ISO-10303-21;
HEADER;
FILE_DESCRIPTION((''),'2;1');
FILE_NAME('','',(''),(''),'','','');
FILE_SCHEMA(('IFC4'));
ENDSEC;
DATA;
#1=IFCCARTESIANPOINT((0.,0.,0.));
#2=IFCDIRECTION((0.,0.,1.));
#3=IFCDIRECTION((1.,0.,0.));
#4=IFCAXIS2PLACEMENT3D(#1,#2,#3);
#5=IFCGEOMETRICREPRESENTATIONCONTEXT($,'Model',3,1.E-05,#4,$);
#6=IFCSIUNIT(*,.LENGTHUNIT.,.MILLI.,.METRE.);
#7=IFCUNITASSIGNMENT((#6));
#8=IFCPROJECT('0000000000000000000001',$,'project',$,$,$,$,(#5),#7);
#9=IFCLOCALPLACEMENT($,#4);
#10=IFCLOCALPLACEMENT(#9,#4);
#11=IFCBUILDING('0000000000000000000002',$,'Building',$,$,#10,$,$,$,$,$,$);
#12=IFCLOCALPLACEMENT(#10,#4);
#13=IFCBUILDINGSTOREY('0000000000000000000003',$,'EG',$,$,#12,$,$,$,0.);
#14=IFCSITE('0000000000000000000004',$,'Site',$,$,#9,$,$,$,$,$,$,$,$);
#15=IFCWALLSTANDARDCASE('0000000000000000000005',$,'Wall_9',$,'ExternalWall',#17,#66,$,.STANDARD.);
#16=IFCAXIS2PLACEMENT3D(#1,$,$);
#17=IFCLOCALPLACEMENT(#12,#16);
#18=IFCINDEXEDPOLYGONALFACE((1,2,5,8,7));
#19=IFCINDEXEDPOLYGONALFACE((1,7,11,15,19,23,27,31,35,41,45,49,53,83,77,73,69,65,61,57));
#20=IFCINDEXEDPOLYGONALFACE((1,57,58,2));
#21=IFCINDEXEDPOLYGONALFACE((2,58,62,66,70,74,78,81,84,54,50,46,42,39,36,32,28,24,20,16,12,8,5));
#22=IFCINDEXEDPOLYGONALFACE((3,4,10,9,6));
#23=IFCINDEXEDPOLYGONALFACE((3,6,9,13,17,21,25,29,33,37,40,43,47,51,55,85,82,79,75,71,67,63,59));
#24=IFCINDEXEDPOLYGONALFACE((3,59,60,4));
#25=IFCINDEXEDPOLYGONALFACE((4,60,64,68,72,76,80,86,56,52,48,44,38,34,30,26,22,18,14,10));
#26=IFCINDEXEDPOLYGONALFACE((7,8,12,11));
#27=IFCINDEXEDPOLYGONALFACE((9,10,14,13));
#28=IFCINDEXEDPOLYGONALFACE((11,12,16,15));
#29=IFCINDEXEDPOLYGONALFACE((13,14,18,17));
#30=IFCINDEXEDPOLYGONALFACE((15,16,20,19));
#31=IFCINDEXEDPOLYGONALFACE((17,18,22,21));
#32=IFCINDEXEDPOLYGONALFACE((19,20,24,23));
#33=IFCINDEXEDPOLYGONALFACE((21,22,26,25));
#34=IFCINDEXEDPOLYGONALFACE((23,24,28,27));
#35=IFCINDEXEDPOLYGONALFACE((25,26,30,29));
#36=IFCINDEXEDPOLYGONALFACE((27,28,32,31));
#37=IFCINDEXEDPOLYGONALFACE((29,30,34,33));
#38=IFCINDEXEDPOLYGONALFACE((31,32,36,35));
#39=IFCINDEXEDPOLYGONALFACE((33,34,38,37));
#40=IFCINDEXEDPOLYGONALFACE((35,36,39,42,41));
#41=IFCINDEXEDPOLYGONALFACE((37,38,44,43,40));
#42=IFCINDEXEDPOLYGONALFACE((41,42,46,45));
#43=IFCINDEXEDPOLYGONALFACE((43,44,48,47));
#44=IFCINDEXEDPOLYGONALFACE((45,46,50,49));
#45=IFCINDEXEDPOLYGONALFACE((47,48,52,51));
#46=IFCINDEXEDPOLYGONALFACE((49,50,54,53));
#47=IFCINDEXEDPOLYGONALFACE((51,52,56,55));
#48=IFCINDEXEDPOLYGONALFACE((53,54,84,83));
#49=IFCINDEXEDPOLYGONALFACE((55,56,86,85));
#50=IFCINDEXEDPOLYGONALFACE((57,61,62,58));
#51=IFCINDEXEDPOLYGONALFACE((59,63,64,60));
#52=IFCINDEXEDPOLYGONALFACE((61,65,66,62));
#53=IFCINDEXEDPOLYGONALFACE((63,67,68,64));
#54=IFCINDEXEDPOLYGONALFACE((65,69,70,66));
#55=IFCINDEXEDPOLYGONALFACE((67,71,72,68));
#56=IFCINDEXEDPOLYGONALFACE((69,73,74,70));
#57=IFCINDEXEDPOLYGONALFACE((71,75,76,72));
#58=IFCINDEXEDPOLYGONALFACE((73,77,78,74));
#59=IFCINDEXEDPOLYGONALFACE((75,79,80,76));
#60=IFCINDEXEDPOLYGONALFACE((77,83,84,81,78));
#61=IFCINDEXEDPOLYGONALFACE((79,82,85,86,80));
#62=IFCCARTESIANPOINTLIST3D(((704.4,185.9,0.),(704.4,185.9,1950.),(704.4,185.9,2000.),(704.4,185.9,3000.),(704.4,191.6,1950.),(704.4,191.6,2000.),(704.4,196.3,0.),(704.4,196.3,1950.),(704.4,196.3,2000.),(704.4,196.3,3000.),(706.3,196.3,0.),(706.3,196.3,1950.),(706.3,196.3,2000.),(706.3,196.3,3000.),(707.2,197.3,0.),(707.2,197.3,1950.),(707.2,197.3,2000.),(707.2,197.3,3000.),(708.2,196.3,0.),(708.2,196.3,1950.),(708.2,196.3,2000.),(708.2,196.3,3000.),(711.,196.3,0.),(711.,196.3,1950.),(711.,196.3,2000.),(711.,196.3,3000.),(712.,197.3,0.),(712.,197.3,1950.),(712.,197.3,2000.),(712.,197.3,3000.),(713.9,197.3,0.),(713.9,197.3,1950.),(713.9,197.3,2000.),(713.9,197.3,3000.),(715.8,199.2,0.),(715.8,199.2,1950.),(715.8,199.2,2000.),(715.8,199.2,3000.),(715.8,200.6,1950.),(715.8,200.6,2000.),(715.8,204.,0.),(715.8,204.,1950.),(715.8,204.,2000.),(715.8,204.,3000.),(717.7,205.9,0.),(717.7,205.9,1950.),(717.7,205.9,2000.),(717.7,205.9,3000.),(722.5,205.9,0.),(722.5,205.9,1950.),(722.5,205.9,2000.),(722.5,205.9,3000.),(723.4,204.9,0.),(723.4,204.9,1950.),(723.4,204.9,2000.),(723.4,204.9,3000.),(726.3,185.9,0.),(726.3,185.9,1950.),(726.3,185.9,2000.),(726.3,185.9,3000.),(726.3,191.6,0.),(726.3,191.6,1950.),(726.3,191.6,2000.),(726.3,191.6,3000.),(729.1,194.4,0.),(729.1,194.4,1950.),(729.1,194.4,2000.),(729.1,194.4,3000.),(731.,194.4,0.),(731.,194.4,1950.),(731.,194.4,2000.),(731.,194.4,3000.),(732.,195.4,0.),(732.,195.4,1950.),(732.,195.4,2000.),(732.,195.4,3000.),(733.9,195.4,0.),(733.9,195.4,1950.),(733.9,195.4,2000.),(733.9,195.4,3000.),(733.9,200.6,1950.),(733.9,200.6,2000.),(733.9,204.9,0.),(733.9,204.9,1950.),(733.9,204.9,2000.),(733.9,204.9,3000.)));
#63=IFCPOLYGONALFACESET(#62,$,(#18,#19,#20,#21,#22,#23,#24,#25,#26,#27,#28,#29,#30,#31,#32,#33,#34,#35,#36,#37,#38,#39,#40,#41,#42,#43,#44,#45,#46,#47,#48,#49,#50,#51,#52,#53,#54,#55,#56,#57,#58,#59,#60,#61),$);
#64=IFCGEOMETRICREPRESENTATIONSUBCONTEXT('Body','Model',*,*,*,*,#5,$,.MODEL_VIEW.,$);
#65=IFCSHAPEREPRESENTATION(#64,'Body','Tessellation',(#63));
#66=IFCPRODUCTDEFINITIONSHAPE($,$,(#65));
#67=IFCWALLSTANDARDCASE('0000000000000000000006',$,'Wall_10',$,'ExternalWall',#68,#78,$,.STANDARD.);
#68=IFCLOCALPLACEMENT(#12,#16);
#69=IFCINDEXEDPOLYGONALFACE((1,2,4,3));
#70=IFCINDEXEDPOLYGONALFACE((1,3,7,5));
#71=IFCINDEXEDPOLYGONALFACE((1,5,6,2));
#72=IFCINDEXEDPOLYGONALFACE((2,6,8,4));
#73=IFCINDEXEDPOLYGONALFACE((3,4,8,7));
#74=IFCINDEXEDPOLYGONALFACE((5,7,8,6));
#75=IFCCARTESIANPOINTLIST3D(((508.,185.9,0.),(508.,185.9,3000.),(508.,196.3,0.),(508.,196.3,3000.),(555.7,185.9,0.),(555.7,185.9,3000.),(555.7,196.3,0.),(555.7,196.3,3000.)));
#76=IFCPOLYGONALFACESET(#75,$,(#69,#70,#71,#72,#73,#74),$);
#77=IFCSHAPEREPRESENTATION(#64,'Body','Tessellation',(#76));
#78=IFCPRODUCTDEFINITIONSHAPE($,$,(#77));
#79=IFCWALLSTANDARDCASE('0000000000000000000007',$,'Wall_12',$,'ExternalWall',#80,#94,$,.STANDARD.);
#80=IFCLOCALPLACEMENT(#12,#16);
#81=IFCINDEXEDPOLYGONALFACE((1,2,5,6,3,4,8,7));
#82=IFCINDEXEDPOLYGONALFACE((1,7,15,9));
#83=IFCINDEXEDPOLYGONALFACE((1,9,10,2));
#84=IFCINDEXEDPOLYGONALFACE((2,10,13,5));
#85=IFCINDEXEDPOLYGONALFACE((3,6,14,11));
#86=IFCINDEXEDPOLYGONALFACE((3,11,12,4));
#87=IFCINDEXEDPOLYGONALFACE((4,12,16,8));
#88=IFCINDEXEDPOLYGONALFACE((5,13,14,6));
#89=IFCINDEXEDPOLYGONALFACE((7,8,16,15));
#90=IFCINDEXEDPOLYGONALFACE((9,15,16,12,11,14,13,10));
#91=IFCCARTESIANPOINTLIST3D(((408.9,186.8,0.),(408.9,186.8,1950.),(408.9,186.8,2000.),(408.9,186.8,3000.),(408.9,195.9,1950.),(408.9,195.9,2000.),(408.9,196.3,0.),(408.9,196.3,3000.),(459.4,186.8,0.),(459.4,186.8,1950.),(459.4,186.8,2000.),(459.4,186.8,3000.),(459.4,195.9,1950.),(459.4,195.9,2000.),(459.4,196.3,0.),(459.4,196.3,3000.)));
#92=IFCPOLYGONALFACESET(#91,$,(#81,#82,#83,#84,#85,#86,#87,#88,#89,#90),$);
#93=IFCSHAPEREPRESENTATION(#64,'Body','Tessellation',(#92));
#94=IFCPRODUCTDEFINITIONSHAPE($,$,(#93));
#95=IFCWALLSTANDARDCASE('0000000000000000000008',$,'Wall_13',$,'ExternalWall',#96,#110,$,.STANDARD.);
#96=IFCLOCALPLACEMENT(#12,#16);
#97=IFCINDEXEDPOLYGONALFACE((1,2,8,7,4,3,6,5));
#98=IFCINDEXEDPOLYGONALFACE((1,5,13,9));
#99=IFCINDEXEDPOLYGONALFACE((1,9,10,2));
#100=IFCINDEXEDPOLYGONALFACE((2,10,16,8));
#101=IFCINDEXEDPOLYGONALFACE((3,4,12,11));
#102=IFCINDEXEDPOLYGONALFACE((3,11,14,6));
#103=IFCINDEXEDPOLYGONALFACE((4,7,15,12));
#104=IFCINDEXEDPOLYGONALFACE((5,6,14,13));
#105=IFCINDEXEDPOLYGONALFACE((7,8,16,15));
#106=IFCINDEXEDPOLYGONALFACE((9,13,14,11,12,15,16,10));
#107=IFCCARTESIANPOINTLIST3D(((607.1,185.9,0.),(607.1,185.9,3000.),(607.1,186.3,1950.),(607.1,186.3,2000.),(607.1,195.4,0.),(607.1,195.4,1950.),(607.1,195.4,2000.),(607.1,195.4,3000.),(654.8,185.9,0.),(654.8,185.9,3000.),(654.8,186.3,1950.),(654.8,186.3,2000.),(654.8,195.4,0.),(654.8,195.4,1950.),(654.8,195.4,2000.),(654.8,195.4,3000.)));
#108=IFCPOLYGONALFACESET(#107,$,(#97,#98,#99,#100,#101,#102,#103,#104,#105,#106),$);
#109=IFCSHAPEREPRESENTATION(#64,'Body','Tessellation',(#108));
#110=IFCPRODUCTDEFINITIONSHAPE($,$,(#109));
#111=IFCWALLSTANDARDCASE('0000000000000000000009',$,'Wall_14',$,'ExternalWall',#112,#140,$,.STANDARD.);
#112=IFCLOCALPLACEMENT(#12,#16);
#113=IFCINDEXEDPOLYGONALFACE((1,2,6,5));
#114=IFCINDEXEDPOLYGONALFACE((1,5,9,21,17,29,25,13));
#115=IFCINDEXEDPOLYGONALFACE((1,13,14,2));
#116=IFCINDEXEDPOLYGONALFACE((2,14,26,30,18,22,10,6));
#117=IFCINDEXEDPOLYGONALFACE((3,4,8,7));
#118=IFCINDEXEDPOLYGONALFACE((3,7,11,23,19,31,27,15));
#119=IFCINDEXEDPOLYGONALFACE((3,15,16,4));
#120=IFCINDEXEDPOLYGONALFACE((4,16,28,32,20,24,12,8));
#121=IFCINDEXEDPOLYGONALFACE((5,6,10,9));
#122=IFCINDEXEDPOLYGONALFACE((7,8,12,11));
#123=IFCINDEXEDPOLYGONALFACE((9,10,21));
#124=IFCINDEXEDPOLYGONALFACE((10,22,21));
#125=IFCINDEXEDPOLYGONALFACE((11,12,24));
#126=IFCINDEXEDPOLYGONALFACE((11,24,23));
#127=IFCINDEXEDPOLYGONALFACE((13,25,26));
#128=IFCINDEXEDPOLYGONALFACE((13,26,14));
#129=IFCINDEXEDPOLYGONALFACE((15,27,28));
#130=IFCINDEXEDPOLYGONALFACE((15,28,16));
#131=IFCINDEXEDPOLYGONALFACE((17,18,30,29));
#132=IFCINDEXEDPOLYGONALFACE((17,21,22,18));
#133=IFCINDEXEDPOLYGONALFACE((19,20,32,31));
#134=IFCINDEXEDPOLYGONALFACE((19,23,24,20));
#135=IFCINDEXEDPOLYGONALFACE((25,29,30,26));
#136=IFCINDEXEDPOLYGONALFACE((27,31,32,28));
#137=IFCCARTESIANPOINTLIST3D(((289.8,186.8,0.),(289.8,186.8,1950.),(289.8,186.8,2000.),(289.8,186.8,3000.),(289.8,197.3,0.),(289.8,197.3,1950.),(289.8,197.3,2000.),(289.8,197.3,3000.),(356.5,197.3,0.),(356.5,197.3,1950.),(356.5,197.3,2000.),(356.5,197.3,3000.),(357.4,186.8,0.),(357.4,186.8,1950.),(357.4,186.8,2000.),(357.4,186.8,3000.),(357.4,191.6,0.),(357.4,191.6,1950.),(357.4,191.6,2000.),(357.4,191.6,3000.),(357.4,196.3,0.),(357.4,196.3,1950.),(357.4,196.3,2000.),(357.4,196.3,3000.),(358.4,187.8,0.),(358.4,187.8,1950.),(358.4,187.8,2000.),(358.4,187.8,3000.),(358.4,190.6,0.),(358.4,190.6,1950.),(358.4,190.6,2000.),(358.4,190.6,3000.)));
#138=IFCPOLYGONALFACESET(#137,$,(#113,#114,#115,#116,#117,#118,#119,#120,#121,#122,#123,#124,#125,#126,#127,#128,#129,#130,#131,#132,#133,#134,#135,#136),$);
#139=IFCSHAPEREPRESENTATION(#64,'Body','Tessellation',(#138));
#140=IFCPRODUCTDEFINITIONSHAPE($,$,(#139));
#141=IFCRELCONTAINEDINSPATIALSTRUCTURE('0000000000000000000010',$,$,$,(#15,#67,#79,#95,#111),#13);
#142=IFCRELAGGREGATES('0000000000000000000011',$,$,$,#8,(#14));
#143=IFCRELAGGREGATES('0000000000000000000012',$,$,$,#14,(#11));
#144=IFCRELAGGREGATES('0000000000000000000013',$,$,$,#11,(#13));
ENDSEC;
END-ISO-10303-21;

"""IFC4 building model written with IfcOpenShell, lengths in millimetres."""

from ifc_helpers import new_model, si_unit, frame, origin_with_axes, place, context, subcontext, project, spatial, polyline, rectangle, outline, extrude, element, save


model = new_model("IFC4")

# Units and contexts
model_context = context("Model", 3, precision=1e-05, world=origin_with_axes())
body_context = subcontext(model_context, "Body", "Model", "MODEL_VIEW")
ifc_project = project(units=[si_unit("LENGTHUNIT", "METRE", prefix="MILLI")], contexts=[model_context])

# Site, building, storey
site_placement = place(None, origin_with_axes())
site = spatial("IfcSite", under=ifc_project, at=site_placement, Name="Site")
building_placement = place(site_placement, origin_with_axes())
building = spatial("IfcBuilding", under=site, at=building_placement, Name="Building")
storey_placement = place(building_placement, origin_with_axes())
storey = spatial("IfcBuildingStorey", under=building, at=storey_placement, Name="EG", Elevation=0.0)

# Wall, openings
wall_1_placement = place(storey_placement, origin_with_axes())
wall_1 = element("IfcWallStandardCase", 1, at=wall_1_placement, inside=storey, Name="Wall_9", ObjectType="ExternalWall", PredefinedType="STANDARD", context=body_context, shape_type="SweptSolid", body=[
    extrude(outline(polyline([(704.4, 185.9, 0.0), (704.4, 196.3, 0.0), (706.3, 196.3, 0.0), (707.2, 197.3, 0.0), (708.2, 196.3, 0.0), (711.0, 196.3, 0.0), (712.0, 197.3, 0.0), (713.9, 197.3, 0.0), (715.8, 199.2, 0.0), (715.8, 204.0, 0.0), (717.7, 205.9, 0.0), (722.5, 205.9, 0.0), (723.4, 204.9, 0.0), (733.9, 204.9, 0.0), (733.9, 195.4, 0.0), (732.0, 195.4, 0.0), (731.0, 194.4, 0.0), (729.1, 194.4, 0.0), (726.3, 191.6, 0.0), (726.3, 185.9, 0.0), (704.4, 185.9, 0.0)])), origin_with_axes(), (0.0, 0.0, 1.0), 3000.0),
])
opening_1_placement = place(wall_1_placement, origin_with_axes())
element("IfcOpeningElement", 2, at=opening_1_placement, inside=storey, cuts=wall_1, context=body_context, shape_type="SweptSolid", body=[
    extrude(rectangle(XDim=1200.0, YDim=20.0), frame((680.1, 190.6, 1950.0), z_axis=(0.0, 0.0, 1.0), x_axis=(1.0, 0.0, 0.0)), (0.0, 0.0, 1.0), 50.0),
])
opening_2_placement = place(wall_1_placement, origin_with_axes())
element("IfcOpeningElement", 3, at=opening_2_placement, inside=storey, cuts=wall_1, context=body_context, shape_type="SweptSolid", body=[
    extrude(rectangle(XDim=1200.0, YDim=20.0), frame((798.7, 201.6, 1950.0), z_axis=(0.0, 0.0, 1.0), x_axis=(1.0, 0.0, 0.0)), (0.0, 0.0, 1.0), 50.0),
])

# Wall
wall_2_placement = place(storey_placement, origin_with_axes())
element("IfcWallStandardCase", 4, at=wall_2_placement, inside=storey, Name="Wall_10", ObjectType="ExternalWall", PredefinedType="STANDARD", context=body_context, shape_type="SweptSolid", body=[
    extrude(outline(polyline([(508.0, 185.9, 0.0), (508.0, 196.3, 0.0), (555.7, 196.3, 0.0), (555.7, 185.9, 0.0), (508.0, 185.9, 0.0)])), origin_with_axes(), (0.0, 0.0, 1.0), 3000.0),
])

# Walls, openings
wall_3_placement = place(storey_placement, origin_with_axes())
wall_3 = element("IfcWallStandardCase", 5, at=wall_3_placement, inside=storey, Name="Wall_12", ObjectType="ExternalWall", PredefinedType="STANDARD", context=body_context, shape_type="SweptSolid", body=[
    extrude(outline(polyline([(408.9, 186.8, 0.0), (408.9, 196.3, 0.0), (459.4, 196.3, 0.0), (459.4, 186.8, 0.0), (408.9, 186.8, 0.0)])), origin_with_axes(), (0.0, 0.0, 1.0), 3000.0),
])
opening_3_placement = place(wall_3_placement, origin_with_axes())
element("IfcOpeningElement", 6, at=opening_3_placement, inside=storey, cuts=wall_3, context=body_context, shape_type="SweptSolid", body=[
    extrude(rectangle(XDim=1200.0, YDim=9.5), frame((483.0, 191.1, 1950.0), z_axis=(0.0, 0.0, 1.0), x_axis=(1.0, 0.0, 0.0)), (0.0, 0.0, 1.0), 50.0),
])
wall_4_placement = place(storey_placement, origin_with_axes())
wall_4 = element("IfcWallStandardCase", 7, at=wall_4_placement, inside=storey, Name="Wall_13", ObjectType="ExternalWall", PredefinedType="STANDARD", context=body_context, shape_type="SweptSolid", body=[
    extrude(outline(polyline([(607.1, 185.9, 0.0), (607.1, 195.4, 0.0), (654.8, 195.4, 0.0), (654.8, 185.9, 0.0), (607.1, 185.9, 0.0)])), origin_with_axes(), (0.0, 0.0, 1.0), 3000.0),
])
opening_4_placement = place(wall_4_placement, origin_with_axes())
element("IfcOpeningElement", 8, at=opening_4_placement, inside=storey, cuts=wall_4, context=body_context, shape_type="SweptSolid", body=[
    extrude(rectangle(XDim=1200.0, YDim=9.5), frame((582.2, 191.1, 1950.0), z_axis=(0.0, 0.0, 1.0), x_axis=(1.0, 0.0, 0.0)), (0.0, 0.0, 1.0), 50.0),
])
wall_5_placement = place(storey_placement, origin_with_axes())
wall_5 = element("IfcWallStandardCase", 9, at=wall_5_placement, inside=storey, Name="Wall_14", ObjectType="ExternalWall", PredefinedType="STANDARD", context=body_context, shape_type="SweptSolid", body=[
    extrude(outline(polyline([(289.8, 186.8, 0.0), (289.8, 197.3, 0.0), (356.5, 197.3, 0.0), (357.4, 196.3, 0.0), (357.4, 191.6, 0.0), (358.4, 190.6, 0.0), (358.4, 187.8, 0.0), (357.4, 186.8, 0.0), (289.8, 186.8, 0.0)])), origin_with_axes(), (0.0, 0.0, 1.0), 3000.0),
])
opening_5_placement = place(wall_5_placement, origin_with_axes())
element("IfcOpeningElement", 10, at=opening_5_placement, inside=storey, cuts=wall_5, context=body_context, shape_type="SweptSolid", body=[
    extrude(rectangle(XDim=1200.0, YDim=10.5), frame((383.1, 192.1, 1950.0), z_axis=(0.0, 0.0, 1.0), x_axis=(1.0, 0.0, 0.0)), (0.0, 0.0, 1.0), 50.0),
])

save(model, "model.ifc")
